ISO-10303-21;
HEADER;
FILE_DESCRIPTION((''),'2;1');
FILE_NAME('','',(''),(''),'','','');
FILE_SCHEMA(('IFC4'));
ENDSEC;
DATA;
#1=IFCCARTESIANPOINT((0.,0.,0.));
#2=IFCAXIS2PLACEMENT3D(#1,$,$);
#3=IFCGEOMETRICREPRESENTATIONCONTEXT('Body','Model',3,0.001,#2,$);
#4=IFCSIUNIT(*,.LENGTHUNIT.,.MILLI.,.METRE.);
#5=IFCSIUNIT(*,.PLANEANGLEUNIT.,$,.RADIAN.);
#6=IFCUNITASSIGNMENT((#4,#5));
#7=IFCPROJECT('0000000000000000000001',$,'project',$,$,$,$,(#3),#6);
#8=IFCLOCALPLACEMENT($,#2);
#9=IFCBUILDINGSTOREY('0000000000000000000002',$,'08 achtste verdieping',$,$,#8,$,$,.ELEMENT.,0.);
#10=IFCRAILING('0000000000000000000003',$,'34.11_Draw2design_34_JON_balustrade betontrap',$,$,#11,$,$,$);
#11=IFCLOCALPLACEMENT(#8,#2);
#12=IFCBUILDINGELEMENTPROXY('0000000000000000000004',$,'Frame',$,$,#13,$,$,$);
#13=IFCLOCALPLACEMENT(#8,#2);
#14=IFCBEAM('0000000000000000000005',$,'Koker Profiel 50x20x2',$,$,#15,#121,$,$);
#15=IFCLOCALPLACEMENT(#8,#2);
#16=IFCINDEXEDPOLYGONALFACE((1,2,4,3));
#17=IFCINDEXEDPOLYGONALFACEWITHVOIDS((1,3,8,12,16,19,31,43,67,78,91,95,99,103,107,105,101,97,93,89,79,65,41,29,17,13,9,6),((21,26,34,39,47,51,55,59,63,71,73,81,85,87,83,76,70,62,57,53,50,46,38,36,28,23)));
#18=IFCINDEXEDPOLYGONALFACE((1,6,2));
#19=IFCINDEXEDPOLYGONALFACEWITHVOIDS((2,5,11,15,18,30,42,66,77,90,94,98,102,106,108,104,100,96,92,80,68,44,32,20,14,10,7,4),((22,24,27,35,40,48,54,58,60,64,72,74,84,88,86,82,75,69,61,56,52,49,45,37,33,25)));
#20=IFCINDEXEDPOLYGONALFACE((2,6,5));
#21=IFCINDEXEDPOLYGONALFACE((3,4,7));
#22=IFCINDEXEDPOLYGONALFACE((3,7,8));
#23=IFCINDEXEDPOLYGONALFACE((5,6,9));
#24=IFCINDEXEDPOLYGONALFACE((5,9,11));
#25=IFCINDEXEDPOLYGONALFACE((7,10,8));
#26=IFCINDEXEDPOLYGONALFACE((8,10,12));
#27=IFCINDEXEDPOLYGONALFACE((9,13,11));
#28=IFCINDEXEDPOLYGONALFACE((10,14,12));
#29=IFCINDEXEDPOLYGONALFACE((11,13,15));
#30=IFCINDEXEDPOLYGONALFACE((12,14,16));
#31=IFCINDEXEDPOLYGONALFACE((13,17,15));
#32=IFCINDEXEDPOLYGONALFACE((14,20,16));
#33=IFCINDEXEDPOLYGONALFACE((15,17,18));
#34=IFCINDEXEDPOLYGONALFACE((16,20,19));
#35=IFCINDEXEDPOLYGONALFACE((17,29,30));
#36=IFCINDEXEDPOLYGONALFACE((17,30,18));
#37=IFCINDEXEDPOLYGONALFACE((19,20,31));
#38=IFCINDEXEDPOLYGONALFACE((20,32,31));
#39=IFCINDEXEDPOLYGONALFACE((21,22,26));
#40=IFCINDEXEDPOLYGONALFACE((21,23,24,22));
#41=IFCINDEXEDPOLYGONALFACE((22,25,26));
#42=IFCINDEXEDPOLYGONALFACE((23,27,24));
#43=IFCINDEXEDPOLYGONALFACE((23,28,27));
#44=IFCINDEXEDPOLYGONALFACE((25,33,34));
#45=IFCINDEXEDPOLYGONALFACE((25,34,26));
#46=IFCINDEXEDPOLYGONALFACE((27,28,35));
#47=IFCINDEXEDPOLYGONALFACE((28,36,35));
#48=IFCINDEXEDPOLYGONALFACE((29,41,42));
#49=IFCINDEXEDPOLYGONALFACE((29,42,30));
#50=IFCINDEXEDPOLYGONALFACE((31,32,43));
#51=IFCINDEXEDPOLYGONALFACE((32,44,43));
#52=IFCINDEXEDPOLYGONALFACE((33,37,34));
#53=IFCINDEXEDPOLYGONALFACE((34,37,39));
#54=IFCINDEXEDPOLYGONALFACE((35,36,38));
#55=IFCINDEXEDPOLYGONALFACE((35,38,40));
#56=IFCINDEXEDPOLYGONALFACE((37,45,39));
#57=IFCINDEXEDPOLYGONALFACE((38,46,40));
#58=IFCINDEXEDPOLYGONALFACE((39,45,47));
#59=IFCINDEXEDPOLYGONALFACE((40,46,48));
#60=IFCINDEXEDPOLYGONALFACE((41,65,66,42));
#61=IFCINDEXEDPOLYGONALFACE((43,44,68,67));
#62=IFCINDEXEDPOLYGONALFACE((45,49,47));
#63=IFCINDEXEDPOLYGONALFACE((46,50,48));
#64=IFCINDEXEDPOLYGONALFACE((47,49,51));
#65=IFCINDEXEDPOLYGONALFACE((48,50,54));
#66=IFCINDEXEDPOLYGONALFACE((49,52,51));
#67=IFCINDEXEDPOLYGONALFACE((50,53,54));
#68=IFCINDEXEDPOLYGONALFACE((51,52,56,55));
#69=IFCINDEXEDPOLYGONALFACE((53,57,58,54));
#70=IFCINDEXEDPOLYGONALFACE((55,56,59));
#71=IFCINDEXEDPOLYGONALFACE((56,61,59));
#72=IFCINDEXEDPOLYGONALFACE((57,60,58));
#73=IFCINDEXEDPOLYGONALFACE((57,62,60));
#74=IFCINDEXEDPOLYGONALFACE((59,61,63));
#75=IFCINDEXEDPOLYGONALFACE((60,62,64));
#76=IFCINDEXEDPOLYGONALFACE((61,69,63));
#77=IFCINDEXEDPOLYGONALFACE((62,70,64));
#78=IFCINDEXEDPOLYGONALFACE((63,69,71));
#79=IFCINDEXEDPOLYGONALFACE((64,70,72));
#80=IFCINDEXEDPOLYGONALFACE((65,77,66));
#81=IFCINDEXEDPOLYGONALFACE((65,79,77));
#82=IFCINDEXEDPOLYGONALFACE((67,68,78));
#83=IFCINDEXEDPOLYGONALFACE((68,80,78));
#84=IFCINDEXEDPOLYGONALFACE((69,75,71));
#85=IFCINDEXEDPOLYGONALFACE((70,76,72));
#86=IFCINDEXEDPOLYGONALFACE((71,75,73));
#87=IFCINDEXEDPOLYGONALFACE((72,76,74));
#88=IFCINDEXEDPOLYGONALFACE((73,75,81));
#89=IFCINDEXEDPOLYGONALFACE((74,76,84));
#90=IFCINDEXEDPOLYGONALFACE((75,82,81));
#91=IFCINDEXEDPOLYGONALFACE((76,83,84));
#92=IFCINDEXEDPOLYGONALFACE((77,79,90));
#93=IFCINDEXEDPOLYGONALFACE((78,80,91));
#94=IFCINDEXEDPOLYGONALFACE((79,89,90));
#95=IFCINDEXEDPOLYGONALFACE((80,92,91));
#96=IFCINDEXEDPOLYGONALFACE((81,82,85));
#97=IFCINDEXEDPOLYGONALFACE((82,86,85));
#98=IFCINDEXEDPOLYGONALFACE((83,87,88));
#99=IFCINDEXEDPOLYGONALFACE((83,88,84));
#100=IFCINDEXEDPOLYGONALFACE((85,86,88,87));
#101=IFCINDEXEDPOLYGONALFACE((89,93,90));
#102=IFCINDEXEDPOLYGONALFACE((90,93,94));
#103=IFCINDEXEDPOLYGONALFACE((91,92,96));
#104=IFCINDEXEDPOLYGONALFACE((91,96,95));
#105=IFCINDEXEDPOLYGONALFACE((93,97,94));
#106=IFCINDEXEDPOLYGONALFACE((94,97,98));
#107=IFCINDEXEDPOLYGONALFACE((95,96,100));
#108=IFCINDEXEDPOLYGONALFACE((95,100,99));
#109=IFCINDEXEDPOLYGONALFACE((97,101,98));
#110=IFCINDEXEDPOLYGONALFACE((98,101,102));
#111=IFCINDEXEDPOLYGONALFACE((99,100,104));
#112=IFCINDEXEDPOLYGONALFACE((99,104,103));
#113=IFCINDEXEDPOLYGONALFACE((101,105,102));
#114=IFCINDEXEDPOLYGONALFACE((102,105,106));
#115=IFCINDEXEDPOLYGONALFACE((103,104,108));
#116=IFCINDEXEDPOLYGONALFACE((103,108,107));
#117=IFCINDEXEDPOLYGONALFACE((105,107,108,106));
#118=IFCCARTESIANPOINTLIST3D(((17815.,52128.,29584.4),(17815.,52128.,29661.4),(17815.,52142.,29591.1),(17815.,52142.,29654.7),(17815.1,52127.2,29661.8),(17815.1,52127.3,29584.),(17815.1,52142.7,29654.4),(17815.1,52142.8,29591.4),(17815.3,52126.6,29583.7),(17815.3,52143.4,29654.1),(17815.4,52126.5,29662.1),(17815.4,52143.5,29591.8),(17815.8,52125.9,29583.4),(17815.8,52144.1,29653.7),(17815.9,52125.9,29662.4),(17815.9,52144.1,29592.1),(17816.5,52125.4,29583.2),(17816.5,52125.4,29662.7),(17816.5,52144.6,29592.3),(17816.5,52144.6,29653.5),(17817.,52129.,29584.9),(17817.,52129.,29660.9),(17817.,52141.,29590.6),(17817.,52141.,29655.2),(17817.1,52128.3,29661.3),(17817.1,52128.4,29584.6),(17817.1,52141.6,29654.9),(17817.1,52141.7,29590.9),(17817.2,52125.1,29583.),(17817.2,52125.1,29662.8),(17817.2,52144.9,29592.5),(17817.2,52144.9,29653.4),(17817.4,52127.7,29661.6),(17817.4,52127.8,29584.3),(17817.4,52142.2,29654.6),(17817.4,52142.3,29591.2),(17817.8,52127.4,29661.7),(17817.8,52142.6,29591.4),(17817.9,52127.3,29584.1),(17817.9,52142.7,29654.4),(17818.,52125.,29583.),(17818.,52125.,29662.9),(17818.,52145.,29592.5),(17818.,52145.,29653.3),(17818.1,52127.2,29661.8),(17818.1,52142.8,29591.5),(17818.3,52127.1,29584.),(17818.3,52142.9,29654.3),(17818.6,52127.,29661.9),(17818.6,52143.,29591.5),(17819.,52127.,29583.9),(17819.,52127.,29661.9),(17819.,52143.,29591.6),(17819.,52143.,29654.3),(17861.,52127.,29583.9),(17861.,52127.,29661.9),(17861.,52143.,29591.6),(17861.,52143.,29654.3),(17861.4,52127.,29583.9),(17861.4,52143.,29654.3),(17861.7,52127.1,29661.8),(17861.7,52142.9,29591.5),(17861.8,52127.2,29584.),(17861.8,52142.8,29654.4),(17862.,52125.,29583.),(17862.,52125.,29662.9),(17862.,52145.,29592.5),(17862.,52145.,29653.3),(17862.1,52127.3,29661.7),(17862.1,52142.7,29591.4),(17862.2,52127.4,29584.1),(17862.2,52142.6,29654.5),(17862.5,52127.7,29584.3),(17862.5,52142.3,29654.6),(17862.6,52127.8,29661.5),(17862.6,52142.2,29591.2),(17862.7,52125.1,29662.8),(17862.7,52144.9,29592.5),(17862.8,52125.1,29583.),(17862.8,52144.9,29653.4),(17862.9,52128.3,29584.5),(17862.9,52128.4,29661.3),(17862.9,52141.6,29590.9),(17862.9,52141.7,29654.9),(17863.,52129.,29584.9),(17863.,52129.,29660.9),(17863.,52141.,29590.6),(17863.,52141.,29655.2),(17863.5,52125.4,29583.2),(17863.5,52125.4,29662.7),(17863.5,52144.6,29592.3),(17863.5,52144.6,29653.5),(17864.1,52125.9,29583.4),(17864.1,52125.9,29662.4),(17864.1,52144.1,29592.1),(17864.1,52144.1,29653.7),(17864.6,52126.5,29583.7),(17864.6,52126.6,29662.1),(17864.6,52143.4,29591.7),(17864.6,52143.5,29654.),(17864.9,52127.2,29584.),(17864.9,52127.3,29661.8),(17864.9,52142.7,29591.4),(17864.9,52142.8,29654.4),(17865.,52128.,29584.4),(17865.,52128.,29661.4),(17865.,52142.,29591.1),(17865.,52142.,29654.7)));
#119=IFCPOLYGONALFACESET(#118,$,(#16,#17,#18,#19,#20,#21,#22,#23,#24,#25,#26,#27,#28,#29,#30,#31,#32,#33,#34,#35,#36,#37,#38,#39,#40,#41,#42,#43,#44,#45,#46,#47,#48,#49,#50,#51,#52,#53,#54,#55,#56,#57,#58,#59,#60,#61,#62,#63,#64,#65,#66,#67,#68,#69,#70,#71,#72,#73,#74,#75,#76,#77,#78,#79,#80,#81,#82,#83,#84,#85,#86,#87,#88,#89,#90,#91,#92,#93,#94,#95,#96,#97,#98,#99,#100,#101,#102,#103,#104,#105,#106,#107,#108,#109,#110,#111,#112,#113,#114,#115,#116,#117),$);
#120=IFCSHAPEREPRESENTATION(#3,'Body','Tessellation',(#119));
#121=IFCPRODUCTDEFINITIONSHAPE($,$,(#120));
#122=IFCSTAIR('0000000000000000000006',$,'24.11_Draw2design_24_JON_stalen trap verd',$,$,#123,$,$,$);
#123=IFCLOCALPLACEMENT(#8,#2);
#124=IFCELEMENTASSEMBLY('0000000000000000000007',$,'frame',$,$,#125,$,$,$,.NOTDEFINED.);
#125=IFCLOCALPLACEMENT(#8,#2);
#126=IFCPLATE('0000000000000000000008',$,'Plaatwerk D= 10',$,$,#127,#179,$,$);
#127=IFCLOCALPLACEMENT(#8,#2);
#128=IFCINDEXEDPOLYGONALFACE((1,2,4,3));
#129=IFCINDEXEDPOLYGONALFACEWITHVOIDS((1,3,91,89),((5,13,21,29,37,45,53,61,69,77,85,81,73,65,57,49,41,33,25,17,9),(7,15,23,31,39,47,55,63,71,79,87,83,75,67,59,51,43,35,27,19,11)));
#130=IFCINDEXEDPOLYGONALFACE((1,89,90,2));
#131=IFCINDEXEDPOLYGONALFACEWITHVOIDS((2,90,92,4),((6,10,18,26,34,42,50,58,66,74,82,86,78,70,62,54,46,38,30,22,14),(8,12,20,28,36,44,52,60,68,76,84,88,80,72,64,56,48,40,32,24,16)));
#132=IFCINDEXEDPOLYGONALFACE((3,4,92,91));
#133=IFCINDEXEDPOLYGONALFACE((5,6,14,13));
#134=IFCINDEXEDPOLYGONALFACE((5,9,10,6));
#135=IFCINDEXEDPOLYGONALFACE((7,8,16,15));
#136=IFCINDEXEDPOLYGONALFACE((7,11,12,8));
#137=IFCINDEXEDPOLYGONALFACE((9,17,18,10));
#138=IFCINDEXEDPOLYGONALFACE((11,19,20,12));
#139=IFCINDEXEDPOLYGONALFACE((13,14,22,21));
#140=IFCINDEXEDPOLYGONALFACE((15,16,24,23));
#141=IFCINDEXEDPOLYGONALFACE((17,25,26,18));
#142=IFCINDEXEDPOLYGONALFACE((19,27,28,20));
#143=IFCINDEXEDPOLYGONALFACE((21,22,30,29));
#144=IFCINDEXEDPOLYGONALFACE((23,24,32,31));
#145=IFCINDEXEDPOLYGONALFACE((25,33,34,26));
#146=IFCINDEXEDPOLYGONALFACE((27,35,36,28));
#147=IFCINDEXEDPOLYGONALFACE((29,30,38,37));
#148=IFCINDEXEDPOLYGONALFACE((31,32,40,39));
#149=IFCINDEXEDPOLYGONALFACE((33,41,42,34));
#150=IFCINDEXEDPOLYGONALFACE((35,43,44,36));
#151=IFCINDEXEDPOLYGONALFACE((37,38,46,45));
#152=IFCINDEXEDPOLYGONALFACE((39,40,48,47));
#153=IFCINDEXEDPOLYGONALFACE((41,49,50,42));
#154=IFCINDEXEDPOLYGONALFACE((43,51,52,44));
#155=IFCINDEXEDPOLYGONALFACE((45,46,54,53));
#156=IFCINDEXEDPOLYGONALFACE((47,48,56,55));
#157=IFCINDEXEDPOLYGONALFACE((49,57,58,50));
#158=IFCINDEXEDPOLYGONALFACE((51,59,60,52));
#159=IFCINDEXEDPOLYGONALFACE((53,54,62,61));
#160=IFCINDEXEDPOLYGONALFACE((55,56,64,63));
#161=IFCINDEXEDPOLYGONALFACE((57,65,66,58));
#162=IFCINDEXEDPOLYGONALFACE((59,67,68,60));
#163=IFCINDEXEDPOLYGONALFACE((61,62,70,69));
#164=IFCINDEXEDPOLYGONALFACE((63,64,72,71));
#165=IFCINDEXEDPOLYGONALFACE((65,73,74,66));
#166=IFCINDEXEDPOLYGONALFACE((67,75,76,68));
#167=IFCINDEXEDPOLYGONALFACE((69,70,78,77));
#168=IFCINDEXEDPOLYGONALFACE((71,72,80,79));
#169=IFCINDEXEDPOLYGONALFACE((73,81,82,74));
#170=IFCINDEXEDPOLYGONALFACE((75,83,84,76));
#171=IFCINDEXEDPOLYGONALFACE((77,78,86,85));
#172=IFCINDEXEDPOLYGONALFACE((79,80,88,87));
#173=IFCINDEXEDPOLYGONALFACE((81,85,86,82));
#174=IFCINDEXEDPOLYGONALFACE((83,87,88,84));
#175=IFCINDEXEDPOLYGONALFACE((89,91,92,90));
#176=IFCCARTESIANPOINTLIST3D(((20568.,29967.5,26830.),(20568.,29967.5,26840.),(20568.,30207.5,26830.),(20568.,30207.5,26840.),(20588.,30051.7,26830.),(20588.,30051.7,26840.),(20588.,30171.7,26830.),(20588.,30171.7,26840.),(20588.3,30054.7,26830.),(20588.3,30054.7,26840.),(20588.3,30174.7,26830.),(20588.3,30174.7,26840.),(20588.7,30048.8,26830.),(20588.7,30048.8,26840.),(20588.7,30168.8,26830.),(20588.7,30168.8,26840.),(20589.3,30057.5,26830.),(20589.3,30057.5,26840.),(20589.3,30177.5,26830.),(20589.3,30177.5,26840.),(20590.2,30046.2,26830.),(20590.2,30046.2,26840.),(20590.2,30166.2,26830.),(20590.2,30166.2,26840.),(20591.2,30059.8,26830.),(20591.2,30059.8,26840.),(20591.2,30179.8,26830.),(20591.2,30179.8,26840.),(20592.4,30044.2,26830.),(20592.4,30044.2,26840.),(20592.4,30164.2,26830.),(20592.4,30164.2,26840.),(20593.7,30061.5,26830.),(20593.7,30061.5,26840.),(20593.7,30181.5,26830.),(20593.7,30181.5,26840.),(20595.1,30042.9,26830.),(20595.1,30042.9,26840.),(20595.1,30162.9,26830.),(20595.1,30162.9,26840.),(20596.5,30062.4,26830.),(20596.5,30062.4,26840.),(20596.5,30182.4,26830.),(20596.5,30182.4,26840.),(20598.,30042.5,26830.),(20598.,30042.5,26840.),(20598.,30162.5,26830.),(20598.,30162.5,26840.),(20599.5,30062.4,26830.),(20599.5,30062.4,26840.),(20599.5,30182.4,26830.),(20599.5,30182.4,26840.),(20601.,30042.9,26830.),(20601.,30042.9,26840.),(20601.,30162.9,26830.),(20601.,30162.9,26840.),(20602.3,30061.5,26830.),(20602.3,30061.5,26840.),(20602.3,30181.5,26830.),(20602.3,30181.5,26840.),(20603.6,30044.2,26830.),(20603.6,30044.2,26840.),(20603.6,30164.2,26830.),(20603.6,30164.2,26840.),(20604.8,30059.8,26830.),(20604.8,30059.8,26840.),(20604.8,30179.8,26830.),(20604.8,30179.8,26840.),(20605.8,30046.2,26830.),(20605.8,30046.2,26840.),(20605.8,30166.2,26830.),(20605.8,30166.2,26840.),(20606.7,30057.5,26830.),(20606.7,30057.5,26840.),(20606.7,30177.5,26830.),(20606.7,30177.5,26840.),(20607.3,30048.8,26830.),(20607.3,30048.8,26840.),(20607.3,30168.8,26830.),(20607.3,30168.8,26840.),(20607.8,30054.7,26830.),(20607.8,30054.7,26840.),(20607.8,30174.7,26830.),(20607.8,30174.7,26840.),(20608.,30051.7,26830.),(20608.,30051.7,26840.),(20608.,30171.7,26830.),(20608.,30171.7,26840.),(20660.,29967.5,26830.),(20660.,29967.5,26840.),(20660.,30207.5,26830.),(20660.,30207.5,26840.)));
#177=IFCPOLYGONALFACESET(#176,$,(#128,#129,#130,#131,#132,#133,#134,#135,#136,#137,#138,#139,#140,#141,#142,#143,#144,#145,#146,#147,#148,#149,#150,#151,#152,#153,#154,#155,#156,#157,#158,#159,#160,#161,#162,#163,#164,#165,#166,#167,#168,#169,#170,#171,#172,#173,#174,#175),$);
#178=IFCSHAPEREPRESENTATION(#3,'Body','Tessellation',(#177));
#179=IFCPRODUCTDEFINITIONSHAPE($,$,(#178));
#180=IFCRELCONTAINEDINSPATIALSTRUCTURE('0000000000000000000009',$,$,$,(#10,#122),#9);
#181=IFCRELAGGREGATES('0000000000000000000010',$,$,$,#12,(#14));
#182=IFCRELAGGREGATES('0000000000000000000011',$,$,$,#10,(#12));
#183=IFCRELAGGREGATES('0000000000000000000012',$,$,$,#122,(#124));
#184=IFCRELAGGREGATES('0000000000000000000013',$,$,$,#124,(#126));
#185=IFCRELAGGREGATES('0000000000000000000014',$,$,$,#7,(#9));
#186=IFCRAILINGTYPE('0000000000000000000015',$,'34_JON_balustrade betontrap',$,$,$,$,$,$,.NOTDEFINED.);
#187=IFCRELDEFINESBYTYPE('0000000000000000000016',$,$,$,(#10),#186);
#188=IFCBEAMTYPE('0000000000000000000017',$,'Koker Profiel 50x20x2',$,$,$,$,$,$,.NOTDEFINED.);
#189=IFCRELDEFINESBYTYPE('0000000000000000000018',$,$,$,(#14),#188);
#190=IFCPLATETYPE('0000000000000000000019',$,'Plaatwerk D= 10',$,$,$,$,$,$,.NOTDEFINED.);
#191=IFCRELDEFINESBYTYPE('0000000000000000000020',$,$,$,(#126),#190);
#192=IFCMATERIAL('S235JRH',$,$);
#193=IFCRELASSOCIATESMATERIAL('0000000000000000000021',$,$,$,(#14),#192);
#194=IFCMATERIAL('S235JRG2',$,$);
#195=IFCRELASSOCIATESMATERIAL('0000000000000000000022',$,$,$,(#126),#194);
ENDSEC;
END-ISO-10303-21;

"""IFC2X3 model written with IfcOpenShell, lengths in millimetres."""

from ifc_helpers import new_model, si_unit, frame, origin, origin_2d, place, context, project, spatial, rectangle, hollow_rectangle, circle, extrude, clip, halfspace, source, transform, mapped, material, type_object, element, aggregate, save


model = new_model("IFC2X3")

# Units and contexts
model_context = context("Model", 3, precision=0.001, world=origin(), identifier="Body")
ifc_project = project(units=[si_unit("LENGTHUNIT", "METRE", prefix="MILLI"), si_unit("PLANEANGLEUNIT", "RADIAN")], contexts=[model_context])

# Storey
storey_placement = place(None, origin())
storey = spatial("IfcBuildingStorey", under=ifc_project, at=storey_placement, Name="08 achtste verdieping", CompositionType="ELEMENT", Elevation=0.0)

# Shared definitions
railing_type_1 = type_object("IfcRailingType", Name="34_JON_balustrade betontrap")
ifc_material_1 = material(Name="S235JRH")
ifc_material_2 = material(Name="S235JRG2")
beam_type_1 = type_object("IfcBeamType", Name="Koker Profiel 50x20x2")

# Railing, building element proxy
railing_1_placement = place(storey_placement, frame((38619.5, 98107.5, -19301.4), z_axis=(0.0, 0.0, 1.0), x_axis=(-1.0, 0.0, 0.0)))
railing_1 = element("IfcRailing", 1, at=railing_1_placement, inside=storey, type_object=railing_type_1, Name="34.11_Draw2design_34_JON_balustrade betontrap")
proxy_1_placement = place(railing_1_placement, origin())
proxy_1 = element("IfcBuildingElementProxy", 2, at=proxy_1_placement, Name="Frame")

# Beam
shared_shape_1 = source(origin(), model_context, "Body", "Clipping", [
    clip(clip(extrude(hollow_rectangle(XDim=20.0, YDim=50.0, WallThickness=2.0, InnerFilletRadius=2.0, OuterFilletRadius=3.0, at=origin_2d()), origin(), (0.0, 0.0, -1.0), 79.9), halfspace(frame((-10.0, 25.0, -9.6), z_axis=(-0.430948, 0.0, 0.902377), x_axis=(0.902377, 0.0, 0.430948)), False)), halfspace(frame((-10.0, -25.0, -70.3), z_axis=(-0.430948, 0.0, -0.902377), x_axis=(-0.902377, 0.0, 0.430948)), False)),
])
beam_1_placement = place(proxy_1_placement, frame((20779.5, 45972.5, 48964.2), z_axis=(0.0, 0.0, 1.0), x_axis=(0.0, 1.0, 0.0)))
beam_1 = element("IfcBeam", 3, at=beam_1_placement, type_object=beam_type_1, material=ifc_material_1, Name="Koker Profiel 50x20x2", context=model_context, shape_type="MappedRepresentation", body=[
    mapped(shared_shape_1, transform((0.0, 0.0, 0.0), scale=1.0)),
])
aggregate(proxy_1, [beam_1])

aggregate(railing_1, [proxy_1])

# Stair
stair_placement = place(storey_placement, frame((19764.0, 30187.5, 27088.2), z_axis=(0.0, 0.0, 1.0), x_axis=(0.0, -1.0, 0.0)))
stair = element("IfcStair", 4, at=stair_placement, inside=storey, Name="24.11_Draw2design_24_JON_stalen trap verd")

# Element assembly
assembly_placement = place(stair_placement, frame((0.0, 876.0, 0.0), z_axis=(0.0, 0.0, -1.0), x_axis=(1.0, 0.0, 0.0)))
assembly = element("IfcElementAssembly", 5, at=assembly_placement, Name="frame", PredefinedType="NOTDEFINED")
aggregate(stair, [assembly])

# Plate, openings
plate_type = type_object("IfcPlateType", Name="Plaatwerk D= 10")
shared_shape_2 = source(origin(), model_context, "Body", "SweptSolid", [
    extrude(rectangle(XDim=92.0, YDim=240.0, at=origin_2d()), frame((46.0, 0.0, -5.0)), (0.0, 0.0, 1.0), 10.0),
])
plate_1_placement = place(assembly_placement, frame((100.0, 72.0, 253.2), z_axis=(0.0, 0.0, 1.0), x_axis=(0.0, -1.0, 0.0)))
plate_1 = element("IfcPlate", 6, at=plate_1_placement, type_object=plate_type, material=ifc_material_2, Name="Plaatwerk D= 10", context=model_context, shape_type="MappedRepresentation", body=[
    mapped(shared_shape_2, transform((0.0, 0.0, 0.0), scale=1.0)),
])
opening_1_placement = place(plate_1_placement, frame((30.0, -85.0, 5.0), z_axis=(0.0, 0.0, -1.0), x_axis=(0.0, 1.0, 0.0)))
element("IfcOpeningElement", 7, at=opening_1_placement, cuts=plate_1, ObjectType="Opening", context=model_context, shape_type="SweptSolid", body=[
    extrude(circle(Radius=10.0, at=origin_2d()), origin(), (0.0, 0.0, 1.0), 10.0),
])
opening_2_placement = place(plate_1_placement, frame((30.0, 35.0, 5.0), z_axis=(0.0, 0.0, -1.0), x_axis=(0.0, 1.0, 0.0)))
element("IfcOpeningElement", 8, at=opening_2_placement, cuts=plate_1, ObjectType="Opening", context=model_context, shape_type="SweptSolid", body=[
    extrude(circle(Radius=10.0, at=origin_2d()), origin(), (0.0, 0.0, 1.0), 10.0),
])
aggregate(assembly, [plate_1])

save(model, "model.ifc")
